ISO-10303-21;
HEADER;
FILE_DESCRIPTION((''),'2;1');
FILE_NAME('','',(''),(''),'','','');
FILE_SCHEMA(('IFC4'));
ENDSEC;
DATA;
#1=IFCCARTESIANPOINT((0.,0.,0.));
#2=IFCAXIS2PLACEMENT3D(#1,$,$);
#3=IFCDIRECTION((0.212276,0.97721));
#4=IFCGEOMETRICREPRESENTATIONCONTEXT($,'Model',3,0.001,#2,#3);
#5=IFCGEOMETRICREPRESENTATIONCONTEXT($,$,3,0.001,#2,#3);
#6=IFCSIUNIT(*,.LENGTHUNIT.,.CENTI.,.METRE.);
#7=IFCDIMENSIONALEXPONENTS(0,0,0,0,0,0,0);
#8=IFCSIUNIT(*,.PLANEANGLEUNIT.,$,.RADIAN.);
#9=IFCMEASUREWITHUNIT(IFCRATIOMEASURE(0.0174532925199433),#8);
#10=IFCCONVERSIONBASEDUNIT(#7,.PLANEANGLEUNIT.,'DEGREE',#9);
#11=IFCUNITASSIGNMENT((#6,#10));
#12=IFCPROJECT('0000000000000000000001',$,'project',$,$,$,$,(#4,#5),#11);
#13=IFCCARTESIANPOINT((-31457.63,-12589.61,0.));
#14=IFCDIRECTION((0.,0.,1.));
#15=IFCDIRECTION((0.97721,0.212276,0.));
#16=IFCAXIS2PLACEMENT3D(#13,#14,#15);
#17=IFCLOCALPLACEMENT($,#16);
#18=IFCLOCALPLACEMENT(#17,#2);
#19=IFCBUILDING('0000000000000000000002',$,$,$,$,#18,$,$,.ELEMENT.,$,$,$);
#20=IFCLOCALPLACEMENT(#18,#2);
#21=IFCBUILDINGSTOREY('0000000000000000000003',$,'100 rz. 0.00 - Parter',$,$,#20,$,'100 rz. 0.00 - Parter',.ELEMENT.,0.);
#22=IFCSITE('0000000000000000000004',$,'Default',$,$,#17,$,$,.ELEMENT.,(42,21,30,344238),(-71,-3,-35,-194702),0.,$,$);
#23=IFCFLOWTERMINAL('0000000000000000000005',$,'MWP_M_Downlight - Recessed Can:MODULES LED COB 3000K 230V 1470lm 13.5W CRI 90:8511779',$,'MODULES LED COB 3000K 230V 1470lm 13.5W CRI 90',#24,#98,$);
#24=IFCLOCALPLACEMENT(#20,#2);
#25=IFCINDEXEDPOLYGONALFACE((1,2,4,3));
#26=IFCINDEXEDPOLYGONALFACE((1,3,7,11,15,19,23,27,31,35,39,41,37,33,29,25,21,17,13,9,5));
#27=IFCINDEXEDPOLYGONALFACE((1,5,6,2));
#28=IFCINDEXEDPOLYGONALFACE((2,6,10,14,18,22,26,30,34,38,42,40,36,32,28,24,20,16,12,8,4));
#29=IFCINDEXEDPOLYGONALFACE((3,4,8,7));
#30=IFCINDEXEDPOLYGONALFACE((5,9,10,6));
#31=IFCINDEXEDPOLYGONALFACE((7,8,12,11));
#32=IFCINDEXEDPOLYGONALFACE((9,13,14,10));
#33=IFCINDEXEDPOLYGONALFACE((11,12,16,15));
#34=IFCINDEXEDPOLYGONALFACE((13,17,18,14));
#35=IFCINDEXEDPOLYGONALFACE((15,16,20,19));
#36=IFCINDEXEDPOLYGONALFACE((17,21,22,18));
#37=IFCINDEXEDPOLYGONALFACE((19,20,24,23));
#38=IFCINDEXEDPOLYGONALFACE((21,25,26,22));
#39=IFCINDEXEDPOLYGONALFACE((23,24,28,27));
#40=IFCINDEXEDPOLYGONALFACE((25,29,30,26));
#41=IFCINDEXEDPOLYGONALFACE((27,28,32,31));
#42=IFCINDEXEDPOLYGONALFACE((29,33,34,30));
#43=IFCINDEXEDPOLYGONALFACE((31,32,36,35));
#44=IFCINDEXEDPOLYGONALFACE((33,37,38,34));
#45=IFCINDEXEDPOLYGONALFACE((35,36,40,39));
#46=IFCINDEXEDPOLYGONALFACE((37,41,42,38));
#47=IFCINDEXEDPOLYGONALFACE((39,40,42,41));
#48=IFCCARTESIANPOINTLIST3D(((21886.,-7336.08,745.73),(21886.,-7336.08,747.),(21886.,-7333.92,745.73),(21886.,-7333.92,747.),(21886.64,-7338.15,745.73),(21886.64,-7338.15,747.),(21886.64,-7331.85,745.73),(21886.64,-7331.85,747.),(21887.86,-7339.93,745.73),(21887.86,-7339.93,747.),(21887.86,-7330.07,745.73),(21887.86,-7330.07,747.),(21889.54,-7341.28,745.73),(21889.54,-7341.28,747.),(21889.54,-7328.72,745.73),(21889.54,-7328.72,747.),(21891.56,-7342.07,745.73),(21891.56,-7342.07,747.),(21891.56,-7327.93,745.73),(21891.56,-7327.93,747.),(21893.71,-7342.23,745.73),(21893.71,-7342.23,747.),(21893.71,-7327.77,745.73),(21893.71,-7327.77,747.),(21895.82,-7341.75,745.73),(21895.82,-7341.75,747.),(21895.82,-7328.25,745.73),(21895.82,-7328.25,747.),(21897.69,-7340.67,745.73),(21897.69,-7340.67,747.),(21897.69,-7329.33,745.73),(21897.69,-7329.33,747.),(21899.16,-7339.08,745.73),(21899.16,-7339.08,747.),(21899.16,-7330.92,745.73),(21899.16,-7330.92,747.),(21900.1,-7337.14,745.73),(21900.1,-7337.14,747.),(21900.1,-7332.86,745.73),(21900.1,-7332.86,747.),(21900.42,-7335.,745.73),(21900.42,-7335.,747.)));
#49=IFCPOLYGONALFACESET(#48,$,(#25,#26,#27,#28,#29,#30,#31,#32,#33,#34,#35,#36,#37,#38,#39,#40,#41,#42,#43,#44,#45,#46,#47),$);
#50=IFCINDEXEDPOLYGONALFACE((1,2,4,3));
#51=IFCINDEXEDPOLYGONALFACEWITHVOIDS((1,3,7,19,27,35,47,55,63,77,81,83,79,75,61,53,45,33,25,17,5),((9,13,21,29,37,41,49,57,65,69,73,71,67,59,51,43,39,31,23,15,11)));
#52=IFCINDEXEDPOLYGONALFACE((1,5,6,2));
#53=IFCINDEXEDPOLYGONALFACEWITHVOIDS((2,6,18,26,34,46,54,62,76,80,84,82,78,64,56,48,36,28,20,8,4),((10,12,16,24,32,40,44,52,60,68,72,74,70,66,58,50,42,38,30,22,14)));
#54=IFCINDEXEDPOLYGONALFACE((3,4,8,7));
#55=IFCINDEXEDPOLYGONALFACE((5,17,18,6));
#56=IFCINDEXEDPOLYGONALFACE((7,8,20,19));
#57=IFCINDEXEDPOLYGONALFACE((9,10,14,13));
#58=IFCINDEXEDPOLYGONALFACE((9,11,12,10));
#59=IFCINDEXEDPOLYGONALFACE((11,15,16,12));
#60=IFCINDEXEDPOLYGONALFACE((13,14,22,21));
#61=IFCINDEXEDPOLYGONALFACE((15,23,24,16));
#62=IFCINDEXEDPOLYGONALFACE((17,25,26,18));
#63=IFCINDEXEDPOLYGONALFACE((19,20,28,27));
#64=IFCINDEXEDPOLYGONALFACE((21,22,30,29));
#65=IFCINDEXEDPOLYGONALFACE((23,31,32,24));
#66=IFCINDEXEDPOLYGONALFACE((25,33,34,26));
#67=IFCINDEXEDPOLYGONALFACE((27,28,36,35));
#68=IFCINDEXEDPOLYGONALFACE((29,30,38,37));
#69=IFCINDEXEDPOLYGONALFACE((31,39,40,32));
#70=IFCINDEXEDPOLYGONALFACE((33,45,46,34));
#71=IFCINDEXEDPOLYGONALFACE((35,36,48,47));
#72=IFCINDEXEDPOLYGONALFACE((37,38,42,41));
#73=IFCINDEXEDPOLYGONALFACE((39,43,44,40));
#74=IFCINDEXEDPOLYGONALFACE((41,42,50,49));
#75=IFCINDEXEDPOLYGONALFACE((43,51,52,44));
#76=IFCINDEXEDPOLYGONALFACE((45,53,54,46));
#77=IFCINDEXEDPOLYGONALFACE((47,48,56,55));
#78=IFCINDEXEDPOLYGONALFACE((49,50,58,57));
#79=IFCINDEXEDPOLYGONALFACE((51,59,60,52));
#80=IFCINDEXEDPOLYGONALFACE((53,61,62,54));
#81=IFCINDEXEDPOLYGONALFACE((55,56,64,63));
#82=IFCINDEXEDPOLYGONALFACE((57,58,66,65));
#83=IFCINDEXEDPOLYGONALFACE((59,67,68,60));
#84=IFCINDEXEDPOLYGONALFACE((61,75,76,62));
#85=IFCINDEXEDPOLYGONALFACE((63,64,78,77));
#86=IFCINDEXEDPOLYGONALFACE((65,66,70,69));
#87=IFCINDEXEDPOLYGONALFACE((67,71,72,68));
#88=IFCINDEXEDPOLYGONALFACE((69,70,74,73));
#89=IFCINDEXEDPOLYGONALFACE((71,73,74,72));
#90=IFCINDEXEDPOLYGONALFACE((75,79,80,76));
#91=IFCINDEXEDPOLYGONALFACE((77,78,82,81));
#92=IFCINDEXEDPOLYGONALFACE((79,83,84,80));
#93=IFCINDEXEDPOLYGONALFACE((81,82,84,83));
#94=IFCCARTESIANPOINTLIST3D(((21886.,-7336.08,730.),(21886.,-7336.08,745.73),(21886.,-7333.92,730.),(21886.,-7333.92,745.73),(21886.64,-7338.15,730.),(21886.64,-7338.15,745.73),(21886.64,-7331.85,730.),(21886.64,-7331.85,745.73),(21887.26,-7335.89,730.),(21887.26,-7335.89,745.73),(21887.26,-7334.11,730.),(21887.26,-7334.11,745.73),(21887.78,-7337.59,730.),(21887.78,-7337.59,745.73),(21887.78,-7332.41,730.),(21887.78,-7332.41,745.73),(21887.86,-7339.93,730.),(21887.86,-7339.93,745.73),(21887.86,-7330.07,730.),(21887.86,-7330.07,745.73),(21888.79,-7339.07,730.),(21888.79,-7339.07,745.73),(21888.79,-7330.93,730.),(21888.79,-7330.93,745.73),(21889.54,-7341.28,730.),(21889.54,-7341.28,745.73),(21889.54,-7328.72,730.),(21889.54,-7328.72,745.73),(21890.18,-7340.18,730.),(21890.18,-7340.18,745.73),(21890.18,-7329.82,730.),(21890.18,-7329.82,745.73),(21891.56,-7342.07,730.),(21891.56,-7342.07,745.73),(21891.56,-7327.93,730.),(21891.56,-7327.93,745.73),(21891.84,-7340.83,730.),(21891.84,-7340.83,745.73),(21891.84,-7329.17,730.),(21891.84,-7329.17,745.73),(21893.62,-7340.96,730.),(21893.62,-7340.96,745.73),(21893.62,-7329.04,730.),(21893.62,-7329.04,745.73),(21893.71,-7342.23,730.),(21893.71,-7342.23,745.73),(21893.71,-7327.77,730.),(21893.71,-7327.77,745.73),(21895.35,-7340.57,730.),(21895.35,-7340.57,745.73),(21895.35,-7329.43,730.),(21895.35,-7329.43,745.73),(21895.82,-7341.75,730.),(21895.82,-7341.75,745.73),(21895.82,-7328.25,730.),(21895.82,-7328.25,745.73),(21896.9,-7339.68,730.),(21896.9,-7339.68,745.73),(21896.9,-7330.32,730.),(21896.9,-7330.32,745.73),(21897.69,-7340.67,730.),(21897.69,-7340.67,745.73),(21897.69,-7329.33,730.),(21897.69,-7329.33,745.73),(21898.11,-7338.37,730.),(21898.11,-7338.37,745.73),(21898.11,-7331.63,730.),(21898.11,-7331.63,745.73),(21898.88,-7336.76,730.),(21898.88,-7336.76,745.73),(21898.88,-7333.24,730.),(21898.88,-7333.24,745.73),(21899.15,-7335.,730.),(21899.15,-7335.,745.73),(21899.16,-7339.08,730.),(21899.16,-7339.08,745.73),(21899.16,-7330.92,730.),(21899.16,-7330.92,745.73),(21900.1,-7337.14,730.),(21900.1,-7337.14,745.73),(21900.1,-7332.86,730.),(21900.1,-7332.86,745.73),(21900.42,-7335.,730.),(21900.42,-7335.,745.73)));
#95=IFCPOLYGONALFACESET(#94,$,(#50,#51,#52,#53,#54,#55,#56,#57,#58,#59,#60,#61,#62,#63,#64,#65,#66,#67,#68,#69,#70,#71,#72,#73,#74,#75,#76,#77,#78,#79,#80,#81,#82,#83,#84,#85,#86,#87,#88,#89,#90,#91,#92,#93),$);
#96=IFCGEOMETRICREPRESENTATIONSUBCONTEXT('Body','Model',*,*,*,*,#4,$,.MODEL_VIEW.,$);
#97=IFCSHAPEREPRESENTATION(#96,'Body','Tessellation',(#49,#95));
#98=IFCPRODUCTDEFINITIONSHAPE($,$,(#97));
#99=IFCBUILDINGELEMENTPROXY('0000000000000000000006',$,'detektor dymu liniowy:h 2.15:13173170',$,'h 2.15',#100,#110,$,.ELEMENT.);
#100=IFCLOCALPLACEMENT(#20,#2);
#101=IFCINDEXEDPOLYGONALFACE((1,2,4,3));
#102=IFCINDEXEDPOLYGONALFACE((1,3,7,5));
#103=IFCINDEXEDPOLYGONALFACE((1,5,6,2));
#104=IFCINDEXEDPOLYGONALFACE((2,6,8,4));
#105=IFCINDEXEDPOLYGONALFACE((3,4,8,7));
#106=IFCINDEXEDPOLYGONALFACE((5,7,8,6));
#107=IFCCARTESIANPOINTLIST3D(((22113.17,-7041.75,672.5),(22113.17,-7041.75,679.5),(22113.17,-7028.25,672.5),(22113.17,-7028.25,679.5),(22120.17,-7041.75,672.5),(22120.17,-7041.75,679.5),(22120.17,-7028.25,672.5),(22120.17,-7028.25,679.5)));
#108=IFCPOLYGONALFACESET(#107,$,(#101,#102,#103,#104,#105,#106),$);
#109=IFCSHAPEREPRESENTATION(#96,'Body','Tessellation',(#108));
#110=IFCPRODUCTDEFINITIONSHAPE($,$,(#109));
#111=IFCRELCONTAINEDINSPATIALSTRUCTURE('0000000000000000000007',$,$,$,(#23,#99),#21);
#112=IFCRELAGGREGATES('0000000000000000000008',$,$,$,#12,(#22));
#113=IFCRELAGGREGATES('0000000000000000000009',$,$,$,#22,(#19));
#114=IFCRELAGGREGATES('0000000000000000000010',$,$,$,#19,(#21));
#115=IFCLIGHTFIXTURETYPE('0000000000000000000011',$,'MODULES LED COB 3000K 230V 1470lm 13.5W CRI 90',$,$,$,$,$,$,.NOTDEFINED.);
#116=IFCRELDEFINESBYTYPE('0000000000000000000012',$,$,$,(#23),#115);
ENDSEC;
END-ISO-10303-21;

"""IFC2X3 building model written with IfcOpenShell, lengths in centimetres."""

from ifc_helpers import new_model, entity, si_unit, converted_unit, direction, frame, frame_2d, origin, origin_2d_with_axis, place, context, subcontext, project, spatial, rectangle, circle, hollow_circle, extrude, source, transform, mapped, type_object, type_shapes, element, save


model = new_model("IFC2X3")

# Units and contexts
model_context = context("Model", 3, precision=0.001, world=origin(), true_north=direction((0.212276, 0.97721)))
context_of_model = context(None, 3, precision=0.001, world=origin(), true_north=direction((0.212276, 0.97721)))
body_context = subcontext(model_context, "Body", "Model", "MODEL_VIEW")
ifc_project = project(units=[si_unit("LENGTHUNIT", "METRE", prefix="CENTI"), converted_unit("PLANEANGLEUNIT", "DEGREE", entity("IfcRatioMeasure", 0.0174532925199433), si_unit("PLANEANGLEUNIT", "RADIAN"), dimensions=[0, 0, 0, 0, 0, 0, 0])], contexts=[model_context, context_of_model])

# Site, building, storey
site_placement = place(None, frame((-31457.63, -12589.61, 0.0), z_axis=(0.0, 0.0, 1.0), x_axis=(0.97721, 0.212276, 0.0)))
site = spatial("IfcSite", under=ifc_project, at=site_placement, Name="Default", CompositionType="ELEMENT", RefLatitude=(42, 21, 30, 344238), RefLongitude=(-71, -3, -35, -194702), RefElevation=0.0)
building_placement = place(site_placement, origin())
building = spatial("IfcBuilding", under=site, at=building_placement, CompositionType="ELEMENT")
storey_placement = place(building_placement, origin())
storey = spatial("IfcBuildingStorey", under=building, at=storey_placement, Name="100 rz. 0.00 - Parter", LongName="100 rz. 0.00 - Parter", CompositionType="ELEMENT", Elevation=0.0)

# Flow terminal
light_fixture_type_1 = type_object("IfcLightFixtureType", Name="MODULES LED COB 3000K 230V 1470lm 13.5W CRI 90", PredefinedType="NOTDEFINED")
shared_shape_1 = source(origin(), body_context, "Body", "SweptSolid", [
    extrude(circle(Radius=7.25, at=frame_2d((0.0, 0.0), x_axis=(1.0, 0.0))), frame((7.41, 7.41, 15.73)), (0.0, 0.0, 1.0), 1.27),
    extrude(hollow_circle(Radius=7.25, WallThickness=1.27, at=frame_2d((0.0, 0.0), x_axis=(1.0, 0.0))), frame((7.41, 7.41, 0.0)), (0.0, 0.0, 1.0), 15.73),
])
type_shapes(light_fixture_type_1, [shared_shape_1])
for number, where, name in (
    (1, (21885.76, -7342.41, 730.0), "MWP_M_Downlight - Recessed Can:MODULES LED COB 3000K 230V 1470lm 13.5W CRI 90:8511779"),
):
    element("IfcFlowTerminal", number, at=place(storey_placement, frame(where)), inside=storey, type_object=light_fixture_type_1, Name=name, ObjectType="MODULES LED COB 3000K 230V 1470lm 13.5W CRI 90", context=body_context, shape_type="MappedRepresentation", body=[
        mapped(shared_shape_1, transform((0.0, 0.0, 0.0), scale=1.0)),
    ])

# Building element proxy
shared_shape_2 = source(origin(), body_context, "Body", "SweptSolid", [
    extrude(rectangle(XDim=7.0, YDim=13.5, at=origin_2d_with_axis()), frame((6.75, 3.5, 0.0), z_axis=(0.0, 0.0, 1.0), x_axis=(0.0, 1.0, 0.0)), (0.0, 0.0, 1.0), 7.0),
])
proxy_1_placement = place(storey_placement, frame((22120.17, -7041.75, 672.5), z_axis=(0.0, 0.0, 1.0), x_axis=(0.0, 1.0, 0.0)))
element("IfcBuildingElementProxy", 2, at=proxy_1_placement, inside=storey, Name="detektor dymu liniowy:h 2.15:13173170", ObjectType="h 2.15", CompositionType="ELEMENT", context=body_context, shape_type="MappedRepresentation", body=[
    mapped(shared_shape_2, transform((0.0, 0.0, 0.0), scale=1.0)),
])

save(model, "model.ifc")
